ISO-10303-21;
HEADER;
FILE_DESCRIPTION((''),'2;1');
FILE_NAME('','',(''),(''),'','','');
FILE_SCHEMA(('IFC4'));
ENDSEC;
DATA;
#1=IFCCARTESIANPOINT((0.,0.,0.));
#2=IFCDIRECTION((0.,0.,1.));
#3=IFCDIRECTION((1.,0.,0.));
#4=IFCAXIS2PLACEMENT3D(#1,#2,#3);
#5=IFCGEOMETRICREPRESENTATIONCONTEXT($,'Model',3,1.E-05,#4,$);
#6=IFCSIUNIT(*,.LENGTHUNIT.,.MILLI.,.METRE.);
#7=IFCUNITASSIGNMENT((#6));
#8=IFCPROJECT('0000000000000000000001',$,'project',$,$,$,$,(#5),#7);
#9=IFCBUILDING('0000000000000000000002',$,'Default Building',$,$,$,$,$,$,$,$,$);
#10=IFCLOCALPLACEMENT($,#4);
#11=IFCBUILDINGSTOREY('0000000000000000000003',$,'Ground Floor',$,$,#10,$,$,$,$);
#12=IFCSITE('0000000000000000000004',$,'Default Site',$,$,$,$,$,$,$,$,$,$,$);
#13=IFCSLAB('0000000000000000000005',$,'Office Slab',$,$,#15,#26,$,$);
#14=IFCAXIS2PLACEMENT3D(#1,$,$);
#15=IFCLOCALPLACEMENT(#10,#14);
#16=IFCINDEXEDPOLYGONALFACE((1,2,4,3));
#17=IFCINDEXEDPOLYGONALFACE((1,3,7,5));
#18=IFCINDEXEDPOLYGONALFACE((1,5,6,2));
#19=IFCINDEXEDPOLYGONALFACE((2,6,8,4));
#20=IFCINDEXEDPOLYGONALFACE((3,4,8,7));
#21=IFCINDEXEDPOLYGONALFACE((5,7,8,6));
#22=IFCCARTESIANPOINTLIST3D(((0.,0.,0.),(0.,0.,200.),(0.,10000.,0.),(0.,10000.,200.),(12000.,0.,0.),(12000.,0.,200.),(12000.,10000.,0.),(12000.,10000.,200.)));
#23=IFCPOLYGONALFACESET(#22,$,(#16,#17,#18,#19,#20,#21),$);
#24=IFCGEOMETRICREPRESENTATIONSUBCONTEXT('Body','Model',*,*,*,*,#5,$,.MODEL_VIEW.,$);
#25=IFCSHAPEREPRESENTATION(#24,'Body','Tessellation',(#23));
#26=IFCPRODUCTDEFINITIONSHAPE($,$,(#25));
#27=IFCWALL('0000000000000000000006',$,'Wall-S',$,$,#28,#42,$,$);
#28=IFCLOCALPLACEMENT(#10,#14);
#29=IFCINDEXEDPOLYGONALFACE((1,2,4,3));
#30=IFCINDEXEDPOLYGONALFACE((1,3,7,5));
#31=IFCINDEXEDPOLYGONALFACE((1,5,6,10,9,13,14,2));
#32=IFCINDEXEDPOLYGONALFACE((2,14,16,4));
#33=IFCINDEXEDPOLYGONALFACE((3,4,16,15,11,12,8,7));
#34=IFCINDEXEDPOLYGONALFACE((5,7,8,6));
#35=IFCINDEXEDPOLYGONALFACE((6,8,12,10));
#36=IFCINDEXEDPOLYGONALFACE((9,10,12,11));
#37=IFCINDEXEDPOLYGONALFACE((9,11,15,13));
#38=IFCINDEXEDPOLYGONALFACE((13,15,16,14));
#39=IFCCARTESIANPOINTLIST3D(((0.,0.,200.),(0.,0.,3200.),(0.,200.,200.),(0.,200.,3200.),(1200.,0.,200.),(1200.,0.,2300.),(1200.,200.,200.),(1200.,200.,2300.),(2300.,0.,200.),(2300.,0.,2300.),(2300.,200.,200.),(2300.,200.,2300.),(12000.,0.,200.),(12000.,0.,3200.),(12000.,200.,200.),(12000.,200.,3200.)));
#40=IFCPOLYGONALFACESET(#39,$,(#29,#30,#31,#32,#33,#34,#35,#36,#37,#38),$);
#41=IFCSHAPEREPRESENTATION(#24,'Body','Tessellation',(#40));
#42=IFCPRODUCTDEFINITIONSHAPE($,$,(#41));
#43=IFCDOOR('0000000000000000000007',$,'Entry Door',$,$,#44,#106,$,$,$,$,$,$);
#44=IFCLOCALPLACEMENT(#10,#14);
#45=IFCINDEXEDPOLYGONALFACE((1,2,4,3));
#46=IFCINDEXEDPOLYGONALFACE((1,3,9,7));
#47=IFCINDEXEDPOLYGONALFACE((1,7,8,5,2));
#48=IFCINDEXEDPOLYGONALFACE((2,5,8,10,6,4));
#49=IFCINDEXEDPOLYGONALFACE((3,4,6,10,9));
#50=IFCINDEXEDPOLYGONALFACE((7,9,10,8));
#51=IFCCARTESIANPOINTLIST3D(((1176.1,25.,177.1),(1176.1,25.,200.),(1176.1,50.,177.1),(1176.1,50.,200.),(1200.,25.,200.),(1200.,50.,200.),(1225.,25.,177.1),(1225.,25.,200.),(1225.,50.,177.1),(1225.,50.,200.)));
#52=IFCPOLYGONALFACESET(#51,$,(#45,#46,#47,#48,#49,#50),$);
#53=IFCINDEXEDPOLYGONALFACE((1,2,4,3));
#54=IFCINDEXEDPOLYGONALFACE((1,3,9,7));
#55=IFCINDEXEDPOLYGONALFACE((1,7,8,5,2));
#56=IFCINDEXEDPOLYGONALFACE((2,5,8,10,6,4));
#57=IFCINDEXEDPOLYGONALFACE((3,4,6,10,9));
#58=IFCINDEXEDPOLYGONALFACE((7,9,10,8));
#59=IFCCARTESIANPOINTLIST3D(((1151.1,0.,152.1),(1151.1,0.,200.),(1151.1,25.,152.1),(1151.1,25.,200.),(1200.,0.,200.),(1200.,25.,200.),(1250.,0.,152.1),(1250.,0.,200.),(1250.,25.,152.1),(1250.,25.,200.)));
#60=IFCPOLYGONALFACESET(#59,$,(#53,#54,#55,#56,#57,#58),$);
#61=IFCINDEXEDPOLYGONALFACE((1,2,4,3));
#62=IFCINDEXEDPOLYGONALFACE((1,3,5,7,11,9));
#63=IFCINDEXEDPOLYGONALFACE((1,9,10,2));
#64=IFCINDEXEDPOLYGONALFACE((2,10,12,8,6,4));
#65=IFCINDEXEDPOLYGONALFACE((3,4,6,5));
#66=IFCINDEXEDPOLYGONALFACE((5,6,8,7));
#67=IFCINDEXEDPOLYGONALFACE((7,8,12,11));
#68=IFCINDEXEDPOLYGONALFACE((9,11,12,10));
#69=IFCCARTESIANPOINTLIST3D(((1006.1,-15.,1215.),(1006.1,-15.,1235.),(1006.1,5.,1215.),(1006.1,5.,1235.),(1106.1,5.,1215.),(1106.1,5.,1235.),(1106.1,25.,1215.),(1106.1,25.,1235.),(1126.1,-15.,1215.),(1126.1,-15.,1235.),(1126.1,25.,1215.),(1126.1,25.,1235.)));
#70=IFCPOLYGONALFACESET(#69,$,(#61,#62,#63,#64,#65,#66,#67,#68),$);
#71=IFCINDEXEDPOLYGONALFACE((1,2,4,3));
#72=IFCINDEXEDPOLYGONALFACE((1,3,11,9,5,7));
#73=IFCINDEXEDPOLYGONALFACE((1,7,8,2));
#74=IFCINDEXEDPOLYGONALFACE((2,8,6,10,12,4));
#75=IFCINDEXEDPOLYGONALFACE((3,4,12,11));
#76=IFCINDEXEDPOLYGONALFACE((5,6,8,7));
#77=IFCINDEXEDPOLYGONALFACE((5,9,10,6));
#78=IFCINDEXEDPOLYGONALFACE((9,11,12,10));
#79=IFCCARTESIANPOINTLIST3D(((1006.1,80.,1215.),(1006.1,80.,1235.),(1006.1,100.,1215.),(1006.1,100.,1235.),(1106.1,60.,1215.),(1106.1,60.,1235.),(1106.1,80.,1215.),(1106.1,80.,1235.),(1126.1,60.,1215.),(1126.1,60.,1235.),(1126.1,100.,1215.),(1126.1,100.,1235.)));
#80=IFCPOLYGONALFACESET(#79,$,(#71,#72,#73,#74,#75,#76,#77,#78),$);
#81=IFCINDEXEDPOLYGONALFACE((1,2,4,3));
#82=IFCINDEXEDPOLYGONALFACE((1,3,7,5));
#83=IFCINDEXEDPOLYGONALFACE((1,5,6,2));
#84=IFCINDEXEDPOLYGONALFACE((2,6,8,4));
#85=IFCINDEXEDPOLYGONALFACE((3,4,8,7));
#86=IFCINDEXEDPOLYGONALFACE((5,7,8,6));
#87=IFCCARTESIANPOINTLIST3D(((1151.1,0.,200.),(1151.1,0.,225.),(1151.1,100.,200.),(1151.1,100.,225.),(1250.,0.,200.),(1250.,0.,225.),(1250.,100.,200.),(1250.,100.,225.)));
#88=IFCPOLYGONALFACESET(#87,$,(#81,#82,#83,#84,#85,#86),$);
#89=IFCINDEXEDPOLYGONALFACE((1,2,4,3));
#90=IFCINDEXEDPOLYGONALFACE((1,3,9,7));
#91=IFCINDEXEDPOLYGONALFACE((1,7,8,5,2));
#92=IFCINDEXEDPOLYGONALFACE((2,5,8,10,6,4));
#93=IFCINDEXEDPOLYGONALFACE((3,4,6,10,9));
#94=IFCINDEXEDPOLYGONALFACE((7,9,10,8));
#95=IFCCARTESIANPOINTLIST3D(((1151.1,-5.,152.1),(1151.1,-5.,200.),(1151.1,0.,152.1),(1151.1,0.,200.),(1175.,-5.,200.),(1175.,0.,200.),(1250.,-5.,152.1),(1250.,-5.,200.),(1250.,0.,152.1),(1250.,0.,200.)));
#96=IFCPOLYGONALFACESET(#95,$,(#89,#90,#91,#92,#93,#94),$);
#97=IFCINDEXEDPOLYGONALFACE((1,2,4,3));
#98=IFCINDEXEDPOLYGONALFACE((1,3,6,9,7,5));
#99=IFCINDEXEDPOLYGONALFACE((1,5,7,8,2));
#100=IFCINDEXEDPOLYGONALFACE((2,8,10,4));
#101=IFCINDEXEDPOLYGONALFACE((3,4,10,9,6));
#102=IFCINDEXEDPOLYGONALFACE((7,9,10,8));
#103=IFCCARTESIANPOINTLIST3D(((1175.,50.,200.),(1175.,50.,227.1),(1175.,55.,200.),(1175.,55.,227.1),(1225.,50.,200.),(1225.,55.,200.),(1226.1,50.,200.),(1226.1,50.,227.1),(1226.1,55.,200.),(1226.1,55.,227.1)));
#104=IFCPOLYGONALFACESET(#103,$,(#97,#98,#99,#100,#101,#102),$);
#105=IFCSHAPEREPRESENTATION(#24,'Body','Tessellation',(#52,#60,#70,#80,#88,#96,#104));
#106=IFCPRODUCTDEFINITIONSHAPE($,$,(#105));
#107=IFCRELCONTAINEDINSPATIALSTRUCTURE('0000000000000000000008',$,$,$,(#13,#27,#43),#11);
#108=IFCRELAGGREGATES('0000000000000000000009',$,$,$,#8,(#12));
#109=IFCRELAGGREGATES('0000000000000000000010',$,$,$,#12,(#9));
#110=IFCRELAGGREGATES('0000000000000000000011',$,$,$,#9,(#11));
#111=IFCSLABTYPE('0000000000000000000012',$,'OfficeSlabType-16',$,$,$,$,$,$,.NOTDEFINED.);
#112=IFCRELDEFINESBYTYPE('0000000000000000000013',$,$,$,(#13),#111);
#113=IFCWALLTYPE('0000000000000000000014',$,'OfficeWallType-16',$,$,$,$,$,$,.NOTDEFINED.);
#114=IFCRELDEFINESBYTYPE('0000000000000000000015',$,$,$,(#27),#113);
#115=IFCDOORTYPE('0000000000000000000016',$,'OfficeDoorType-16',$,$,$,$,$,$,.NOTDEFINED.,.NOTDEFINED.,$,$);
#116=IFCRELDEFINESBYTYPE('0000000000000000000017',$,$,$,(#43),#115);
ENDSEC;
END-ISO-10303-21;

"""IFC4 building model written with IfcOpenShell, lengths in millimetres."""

from ifc_helpers import new_model, si_unit, frame, origin_with_axes, place, context, subcontext, project, spatial, line, indexed_curve, outline, extrude, type_object, element, fill, save


model = new_model("IFC4")

# Units and contexts
model_context = context("Model", 3, precision=1e-05, world=origin_with_axes())
body_context = subcontext(model_context, "Body", "Model", "MODEL_VIEW")
ifc_project = project(units=[si_unit("LENGTHUNIT", "METRE", prefix="MILLI")], contexts=[model_context])

# Site, building, storey
site = spatial("IfcSite", under=ifc_project, Name="Default Site")
building = spatial("IfcBuilding", under=site, Name="Default Building")
storey_placement = place(None, origin_with_axes())
storey = spatial("IfcBuildingStorey", under=building, at=storey_placement, Name="Ground Floor")

# Slab
slab_type = type_object("IfcSlabType", Name="OfficeSlabType-16", PredefinedType="NOTDEFINED")
slab_placement = place(storey_placement, origin_with_axes())
element("IfcSlab", 1, at=slab_placement, inside=storey, type_object=slab_type, Name="Office Slab", context=body_context, shape_type="SweptSolid", body=[
    extrude(outline(indexed_curve([(0.0, 0.0), (12000.0, 0.0), (12000.0, 10000.0), (0.0, 10000.0), (0.0, 0.0)])), None, (0.0, 0.0, 1.0), 200.0),
])

# Wall, opening, door
wall_type = type_object("IfcWallType", Name="OfficeWallType-16", PredefinedType="NOTDEFINED")
wall_1_placement = place(storey_placement, frame((0.0, 0.0, 200.0), z_axis=(0.0, 0.0, 1.0), x_axis=(1.0, 0.0, 0.0)))
wall_1 = element("IfcWall", 2, at=wall_1_placement, inside=storey, type_object=wall_type, Name="Wall-S", context=body_context, shape_type="SweptSolid", body=[
    extrude(outline(indexed_curve([(0.0, 0.0), (12000.0, 0.0), (12000.0, 200.0), (0.0, 200.0), (0.0, 0.0)])), None, (0.0, 0.0, 1.0), 3000.0),
])
opening_1_placement = place(wall_1_placement, origin_with_axes())
opening_1 = element("IfcOpeningElement", 3, at=opening_1_placement, cuts=wall_1, context=body_context, shape_type="SweptSolid", body=[
    extrude(outline(indexed_curve([(1200.0, 0.0), (2300.0, 0.0), (2300.0, 200.0), (1200.0, 200.0), (1200.0, 0.0)])), None, (0.0, 0.0, 1.0), 2100.0),
])
door_type = type_object("IfcDoorType", Name="OfficeDoorType-16", OperationType="NOTDEFINED", PredefinedType="NOTDEFINED")
door_placement = place(storey_placement, frame((1200.0, 0.0, 200.0), z_axis=(0.0, 0.0, 1.0), x_axis=(1.0, 0.0, 0.0)))
door = element("IfcDoor", 4, at=door_placement, inside=storey, type_object=door_type, Name="Entry Door", context=body_context, shape_type="SweptSolid", body=[
    extrude(outline(indexed_curve([(0.0, 0.0), (0.0, 2.1), (1.1, 2.1), (1.1, 0.0), (-23.9, 0.0), (-23.9, -22.9), (25.0, -22.9), (25.0, 0.0)], segments=[line(1, 2, 3, 4, 5, 6, 7, 8, 1)])), frame((0.0, 25.0, 0.0), z_axis=(0.0, -1.0, 0.0), x_axis=(1.0, 0.0, 0.0)), (0.0, 0.0, -1.0), 25.0),
    extrude(outline(indexed_curve([(0.0, 0.0), (0.0, 2.1), (1.1, 2.1), (1.1, 0.0), (-48.9, 0.0), (-48.9, -47.9), (50.0, -47.9), (50.0, 0.0)], segments=[line(1, 2, 3, 4, 5, 6, 7, 8, 1)])), frame((0.0, 0.0, 0.0), z_axis=(0.0, -1.0, 0.0), x_axis=(1.0, 0.0, 0.0)), (0.0, 0.0, -1.0), 25.0),
    extrude(outline(indexed_curve([(0.0, 0.0), (-48.9, 0.0), (-48.9, 35.0), (0.0, 35.0)], segments=[line(1, 2, 3, 4, 1)])), frame((25.0, 25.0, 25.0), z_axis=(0.0, 0.0, 1.0), x_axis=(1.0, 0.0, 0.0)), (0.0, 0.0, 1.0), -47.9),
    extrude(outline(indexed_curve([(0.0, 0.0), (0.0, -40.0), (-120.0, -40.0), (-120.0, -20.0), (-20.0, -20.0), (-20.0, 0.0)], segments=[line(1, 2, 3, 4, 5, 6, 1)])), frame((-73.9, 25.0, 1015.0), z_axis=(0.0, 0.0, 1.0), x_axis=(1.0, 0.0, 0.0)), (0.0, 0.0, 1.0), 20.0),
    extrude(outline(indexed_curve([(0.0, 0.0), (0.0, 40.0), (-120.0, 40.0), (-120.0, 20.0), (-20.0, 20.0), (-20.0, 0.0)], segments=[line(1, 2, 3, 4, 5, 6, 1)])), frame((-73.9, 60.0, 1015.0), z_axis=(0.0, 0.0, 1.0), x_axis=(1.0, 0.0, 0.0)), (0.0, 0.0, 1.0), 20.0),
    extrude(outline(indexed_curve([(0.0, 0.0), (-98.9, 0.0), (-98.9, 100.0), (0.0, 100.0)], segments=[line(1, 2, 3, 4, 1)])), frame((50.0, 0.0, 0.0), z_axis=(0.0, 0.0, 1.0), x_axis=(1.0, 0.0, 0.0)), (0.0, 0.0, 1.0), 25.0),
    extrude(outline(indexed_curve([(0.0, 0.0), (0.0, 27.1), (51.1, 27.1), (51.1, 0.0), (-23.9, 0.0), (-23.9, -47.9), (75.0, -47.9), (75.0, 0.0)], segments=[line(1, 2, 3, 4, 5, 6, 7, 8, 1)])), frame((-25.0, -5.0, 0.0), z_axis=(0.0, -1.0, 0.0), x_axis=(1.0, 0.0, 0.0)), (0.0, 0.0, -1.0), 5.0),
    extrude(outline(indexed_curve([(0.0, 0.0), (0.0, 27.1), (51.1, 27.1), (51.1, 0.0), (1.1, 0.0), (1.1, -22.9), (50.0, -22.9), (50.0, 0.0)], segments=[line(1, 2, 3, 4, 5, 6, 7, 8, 1)])), frame((-25.0, 50.0, 0.0), z_axis=(0.0, -1.0, 0.0), x_axis=(1.0, 0.0, 0.0)), (0.0, 0.0, -1.0), 5.0),
])
fill(opening_1, door)

save(model, "model.ifc")
